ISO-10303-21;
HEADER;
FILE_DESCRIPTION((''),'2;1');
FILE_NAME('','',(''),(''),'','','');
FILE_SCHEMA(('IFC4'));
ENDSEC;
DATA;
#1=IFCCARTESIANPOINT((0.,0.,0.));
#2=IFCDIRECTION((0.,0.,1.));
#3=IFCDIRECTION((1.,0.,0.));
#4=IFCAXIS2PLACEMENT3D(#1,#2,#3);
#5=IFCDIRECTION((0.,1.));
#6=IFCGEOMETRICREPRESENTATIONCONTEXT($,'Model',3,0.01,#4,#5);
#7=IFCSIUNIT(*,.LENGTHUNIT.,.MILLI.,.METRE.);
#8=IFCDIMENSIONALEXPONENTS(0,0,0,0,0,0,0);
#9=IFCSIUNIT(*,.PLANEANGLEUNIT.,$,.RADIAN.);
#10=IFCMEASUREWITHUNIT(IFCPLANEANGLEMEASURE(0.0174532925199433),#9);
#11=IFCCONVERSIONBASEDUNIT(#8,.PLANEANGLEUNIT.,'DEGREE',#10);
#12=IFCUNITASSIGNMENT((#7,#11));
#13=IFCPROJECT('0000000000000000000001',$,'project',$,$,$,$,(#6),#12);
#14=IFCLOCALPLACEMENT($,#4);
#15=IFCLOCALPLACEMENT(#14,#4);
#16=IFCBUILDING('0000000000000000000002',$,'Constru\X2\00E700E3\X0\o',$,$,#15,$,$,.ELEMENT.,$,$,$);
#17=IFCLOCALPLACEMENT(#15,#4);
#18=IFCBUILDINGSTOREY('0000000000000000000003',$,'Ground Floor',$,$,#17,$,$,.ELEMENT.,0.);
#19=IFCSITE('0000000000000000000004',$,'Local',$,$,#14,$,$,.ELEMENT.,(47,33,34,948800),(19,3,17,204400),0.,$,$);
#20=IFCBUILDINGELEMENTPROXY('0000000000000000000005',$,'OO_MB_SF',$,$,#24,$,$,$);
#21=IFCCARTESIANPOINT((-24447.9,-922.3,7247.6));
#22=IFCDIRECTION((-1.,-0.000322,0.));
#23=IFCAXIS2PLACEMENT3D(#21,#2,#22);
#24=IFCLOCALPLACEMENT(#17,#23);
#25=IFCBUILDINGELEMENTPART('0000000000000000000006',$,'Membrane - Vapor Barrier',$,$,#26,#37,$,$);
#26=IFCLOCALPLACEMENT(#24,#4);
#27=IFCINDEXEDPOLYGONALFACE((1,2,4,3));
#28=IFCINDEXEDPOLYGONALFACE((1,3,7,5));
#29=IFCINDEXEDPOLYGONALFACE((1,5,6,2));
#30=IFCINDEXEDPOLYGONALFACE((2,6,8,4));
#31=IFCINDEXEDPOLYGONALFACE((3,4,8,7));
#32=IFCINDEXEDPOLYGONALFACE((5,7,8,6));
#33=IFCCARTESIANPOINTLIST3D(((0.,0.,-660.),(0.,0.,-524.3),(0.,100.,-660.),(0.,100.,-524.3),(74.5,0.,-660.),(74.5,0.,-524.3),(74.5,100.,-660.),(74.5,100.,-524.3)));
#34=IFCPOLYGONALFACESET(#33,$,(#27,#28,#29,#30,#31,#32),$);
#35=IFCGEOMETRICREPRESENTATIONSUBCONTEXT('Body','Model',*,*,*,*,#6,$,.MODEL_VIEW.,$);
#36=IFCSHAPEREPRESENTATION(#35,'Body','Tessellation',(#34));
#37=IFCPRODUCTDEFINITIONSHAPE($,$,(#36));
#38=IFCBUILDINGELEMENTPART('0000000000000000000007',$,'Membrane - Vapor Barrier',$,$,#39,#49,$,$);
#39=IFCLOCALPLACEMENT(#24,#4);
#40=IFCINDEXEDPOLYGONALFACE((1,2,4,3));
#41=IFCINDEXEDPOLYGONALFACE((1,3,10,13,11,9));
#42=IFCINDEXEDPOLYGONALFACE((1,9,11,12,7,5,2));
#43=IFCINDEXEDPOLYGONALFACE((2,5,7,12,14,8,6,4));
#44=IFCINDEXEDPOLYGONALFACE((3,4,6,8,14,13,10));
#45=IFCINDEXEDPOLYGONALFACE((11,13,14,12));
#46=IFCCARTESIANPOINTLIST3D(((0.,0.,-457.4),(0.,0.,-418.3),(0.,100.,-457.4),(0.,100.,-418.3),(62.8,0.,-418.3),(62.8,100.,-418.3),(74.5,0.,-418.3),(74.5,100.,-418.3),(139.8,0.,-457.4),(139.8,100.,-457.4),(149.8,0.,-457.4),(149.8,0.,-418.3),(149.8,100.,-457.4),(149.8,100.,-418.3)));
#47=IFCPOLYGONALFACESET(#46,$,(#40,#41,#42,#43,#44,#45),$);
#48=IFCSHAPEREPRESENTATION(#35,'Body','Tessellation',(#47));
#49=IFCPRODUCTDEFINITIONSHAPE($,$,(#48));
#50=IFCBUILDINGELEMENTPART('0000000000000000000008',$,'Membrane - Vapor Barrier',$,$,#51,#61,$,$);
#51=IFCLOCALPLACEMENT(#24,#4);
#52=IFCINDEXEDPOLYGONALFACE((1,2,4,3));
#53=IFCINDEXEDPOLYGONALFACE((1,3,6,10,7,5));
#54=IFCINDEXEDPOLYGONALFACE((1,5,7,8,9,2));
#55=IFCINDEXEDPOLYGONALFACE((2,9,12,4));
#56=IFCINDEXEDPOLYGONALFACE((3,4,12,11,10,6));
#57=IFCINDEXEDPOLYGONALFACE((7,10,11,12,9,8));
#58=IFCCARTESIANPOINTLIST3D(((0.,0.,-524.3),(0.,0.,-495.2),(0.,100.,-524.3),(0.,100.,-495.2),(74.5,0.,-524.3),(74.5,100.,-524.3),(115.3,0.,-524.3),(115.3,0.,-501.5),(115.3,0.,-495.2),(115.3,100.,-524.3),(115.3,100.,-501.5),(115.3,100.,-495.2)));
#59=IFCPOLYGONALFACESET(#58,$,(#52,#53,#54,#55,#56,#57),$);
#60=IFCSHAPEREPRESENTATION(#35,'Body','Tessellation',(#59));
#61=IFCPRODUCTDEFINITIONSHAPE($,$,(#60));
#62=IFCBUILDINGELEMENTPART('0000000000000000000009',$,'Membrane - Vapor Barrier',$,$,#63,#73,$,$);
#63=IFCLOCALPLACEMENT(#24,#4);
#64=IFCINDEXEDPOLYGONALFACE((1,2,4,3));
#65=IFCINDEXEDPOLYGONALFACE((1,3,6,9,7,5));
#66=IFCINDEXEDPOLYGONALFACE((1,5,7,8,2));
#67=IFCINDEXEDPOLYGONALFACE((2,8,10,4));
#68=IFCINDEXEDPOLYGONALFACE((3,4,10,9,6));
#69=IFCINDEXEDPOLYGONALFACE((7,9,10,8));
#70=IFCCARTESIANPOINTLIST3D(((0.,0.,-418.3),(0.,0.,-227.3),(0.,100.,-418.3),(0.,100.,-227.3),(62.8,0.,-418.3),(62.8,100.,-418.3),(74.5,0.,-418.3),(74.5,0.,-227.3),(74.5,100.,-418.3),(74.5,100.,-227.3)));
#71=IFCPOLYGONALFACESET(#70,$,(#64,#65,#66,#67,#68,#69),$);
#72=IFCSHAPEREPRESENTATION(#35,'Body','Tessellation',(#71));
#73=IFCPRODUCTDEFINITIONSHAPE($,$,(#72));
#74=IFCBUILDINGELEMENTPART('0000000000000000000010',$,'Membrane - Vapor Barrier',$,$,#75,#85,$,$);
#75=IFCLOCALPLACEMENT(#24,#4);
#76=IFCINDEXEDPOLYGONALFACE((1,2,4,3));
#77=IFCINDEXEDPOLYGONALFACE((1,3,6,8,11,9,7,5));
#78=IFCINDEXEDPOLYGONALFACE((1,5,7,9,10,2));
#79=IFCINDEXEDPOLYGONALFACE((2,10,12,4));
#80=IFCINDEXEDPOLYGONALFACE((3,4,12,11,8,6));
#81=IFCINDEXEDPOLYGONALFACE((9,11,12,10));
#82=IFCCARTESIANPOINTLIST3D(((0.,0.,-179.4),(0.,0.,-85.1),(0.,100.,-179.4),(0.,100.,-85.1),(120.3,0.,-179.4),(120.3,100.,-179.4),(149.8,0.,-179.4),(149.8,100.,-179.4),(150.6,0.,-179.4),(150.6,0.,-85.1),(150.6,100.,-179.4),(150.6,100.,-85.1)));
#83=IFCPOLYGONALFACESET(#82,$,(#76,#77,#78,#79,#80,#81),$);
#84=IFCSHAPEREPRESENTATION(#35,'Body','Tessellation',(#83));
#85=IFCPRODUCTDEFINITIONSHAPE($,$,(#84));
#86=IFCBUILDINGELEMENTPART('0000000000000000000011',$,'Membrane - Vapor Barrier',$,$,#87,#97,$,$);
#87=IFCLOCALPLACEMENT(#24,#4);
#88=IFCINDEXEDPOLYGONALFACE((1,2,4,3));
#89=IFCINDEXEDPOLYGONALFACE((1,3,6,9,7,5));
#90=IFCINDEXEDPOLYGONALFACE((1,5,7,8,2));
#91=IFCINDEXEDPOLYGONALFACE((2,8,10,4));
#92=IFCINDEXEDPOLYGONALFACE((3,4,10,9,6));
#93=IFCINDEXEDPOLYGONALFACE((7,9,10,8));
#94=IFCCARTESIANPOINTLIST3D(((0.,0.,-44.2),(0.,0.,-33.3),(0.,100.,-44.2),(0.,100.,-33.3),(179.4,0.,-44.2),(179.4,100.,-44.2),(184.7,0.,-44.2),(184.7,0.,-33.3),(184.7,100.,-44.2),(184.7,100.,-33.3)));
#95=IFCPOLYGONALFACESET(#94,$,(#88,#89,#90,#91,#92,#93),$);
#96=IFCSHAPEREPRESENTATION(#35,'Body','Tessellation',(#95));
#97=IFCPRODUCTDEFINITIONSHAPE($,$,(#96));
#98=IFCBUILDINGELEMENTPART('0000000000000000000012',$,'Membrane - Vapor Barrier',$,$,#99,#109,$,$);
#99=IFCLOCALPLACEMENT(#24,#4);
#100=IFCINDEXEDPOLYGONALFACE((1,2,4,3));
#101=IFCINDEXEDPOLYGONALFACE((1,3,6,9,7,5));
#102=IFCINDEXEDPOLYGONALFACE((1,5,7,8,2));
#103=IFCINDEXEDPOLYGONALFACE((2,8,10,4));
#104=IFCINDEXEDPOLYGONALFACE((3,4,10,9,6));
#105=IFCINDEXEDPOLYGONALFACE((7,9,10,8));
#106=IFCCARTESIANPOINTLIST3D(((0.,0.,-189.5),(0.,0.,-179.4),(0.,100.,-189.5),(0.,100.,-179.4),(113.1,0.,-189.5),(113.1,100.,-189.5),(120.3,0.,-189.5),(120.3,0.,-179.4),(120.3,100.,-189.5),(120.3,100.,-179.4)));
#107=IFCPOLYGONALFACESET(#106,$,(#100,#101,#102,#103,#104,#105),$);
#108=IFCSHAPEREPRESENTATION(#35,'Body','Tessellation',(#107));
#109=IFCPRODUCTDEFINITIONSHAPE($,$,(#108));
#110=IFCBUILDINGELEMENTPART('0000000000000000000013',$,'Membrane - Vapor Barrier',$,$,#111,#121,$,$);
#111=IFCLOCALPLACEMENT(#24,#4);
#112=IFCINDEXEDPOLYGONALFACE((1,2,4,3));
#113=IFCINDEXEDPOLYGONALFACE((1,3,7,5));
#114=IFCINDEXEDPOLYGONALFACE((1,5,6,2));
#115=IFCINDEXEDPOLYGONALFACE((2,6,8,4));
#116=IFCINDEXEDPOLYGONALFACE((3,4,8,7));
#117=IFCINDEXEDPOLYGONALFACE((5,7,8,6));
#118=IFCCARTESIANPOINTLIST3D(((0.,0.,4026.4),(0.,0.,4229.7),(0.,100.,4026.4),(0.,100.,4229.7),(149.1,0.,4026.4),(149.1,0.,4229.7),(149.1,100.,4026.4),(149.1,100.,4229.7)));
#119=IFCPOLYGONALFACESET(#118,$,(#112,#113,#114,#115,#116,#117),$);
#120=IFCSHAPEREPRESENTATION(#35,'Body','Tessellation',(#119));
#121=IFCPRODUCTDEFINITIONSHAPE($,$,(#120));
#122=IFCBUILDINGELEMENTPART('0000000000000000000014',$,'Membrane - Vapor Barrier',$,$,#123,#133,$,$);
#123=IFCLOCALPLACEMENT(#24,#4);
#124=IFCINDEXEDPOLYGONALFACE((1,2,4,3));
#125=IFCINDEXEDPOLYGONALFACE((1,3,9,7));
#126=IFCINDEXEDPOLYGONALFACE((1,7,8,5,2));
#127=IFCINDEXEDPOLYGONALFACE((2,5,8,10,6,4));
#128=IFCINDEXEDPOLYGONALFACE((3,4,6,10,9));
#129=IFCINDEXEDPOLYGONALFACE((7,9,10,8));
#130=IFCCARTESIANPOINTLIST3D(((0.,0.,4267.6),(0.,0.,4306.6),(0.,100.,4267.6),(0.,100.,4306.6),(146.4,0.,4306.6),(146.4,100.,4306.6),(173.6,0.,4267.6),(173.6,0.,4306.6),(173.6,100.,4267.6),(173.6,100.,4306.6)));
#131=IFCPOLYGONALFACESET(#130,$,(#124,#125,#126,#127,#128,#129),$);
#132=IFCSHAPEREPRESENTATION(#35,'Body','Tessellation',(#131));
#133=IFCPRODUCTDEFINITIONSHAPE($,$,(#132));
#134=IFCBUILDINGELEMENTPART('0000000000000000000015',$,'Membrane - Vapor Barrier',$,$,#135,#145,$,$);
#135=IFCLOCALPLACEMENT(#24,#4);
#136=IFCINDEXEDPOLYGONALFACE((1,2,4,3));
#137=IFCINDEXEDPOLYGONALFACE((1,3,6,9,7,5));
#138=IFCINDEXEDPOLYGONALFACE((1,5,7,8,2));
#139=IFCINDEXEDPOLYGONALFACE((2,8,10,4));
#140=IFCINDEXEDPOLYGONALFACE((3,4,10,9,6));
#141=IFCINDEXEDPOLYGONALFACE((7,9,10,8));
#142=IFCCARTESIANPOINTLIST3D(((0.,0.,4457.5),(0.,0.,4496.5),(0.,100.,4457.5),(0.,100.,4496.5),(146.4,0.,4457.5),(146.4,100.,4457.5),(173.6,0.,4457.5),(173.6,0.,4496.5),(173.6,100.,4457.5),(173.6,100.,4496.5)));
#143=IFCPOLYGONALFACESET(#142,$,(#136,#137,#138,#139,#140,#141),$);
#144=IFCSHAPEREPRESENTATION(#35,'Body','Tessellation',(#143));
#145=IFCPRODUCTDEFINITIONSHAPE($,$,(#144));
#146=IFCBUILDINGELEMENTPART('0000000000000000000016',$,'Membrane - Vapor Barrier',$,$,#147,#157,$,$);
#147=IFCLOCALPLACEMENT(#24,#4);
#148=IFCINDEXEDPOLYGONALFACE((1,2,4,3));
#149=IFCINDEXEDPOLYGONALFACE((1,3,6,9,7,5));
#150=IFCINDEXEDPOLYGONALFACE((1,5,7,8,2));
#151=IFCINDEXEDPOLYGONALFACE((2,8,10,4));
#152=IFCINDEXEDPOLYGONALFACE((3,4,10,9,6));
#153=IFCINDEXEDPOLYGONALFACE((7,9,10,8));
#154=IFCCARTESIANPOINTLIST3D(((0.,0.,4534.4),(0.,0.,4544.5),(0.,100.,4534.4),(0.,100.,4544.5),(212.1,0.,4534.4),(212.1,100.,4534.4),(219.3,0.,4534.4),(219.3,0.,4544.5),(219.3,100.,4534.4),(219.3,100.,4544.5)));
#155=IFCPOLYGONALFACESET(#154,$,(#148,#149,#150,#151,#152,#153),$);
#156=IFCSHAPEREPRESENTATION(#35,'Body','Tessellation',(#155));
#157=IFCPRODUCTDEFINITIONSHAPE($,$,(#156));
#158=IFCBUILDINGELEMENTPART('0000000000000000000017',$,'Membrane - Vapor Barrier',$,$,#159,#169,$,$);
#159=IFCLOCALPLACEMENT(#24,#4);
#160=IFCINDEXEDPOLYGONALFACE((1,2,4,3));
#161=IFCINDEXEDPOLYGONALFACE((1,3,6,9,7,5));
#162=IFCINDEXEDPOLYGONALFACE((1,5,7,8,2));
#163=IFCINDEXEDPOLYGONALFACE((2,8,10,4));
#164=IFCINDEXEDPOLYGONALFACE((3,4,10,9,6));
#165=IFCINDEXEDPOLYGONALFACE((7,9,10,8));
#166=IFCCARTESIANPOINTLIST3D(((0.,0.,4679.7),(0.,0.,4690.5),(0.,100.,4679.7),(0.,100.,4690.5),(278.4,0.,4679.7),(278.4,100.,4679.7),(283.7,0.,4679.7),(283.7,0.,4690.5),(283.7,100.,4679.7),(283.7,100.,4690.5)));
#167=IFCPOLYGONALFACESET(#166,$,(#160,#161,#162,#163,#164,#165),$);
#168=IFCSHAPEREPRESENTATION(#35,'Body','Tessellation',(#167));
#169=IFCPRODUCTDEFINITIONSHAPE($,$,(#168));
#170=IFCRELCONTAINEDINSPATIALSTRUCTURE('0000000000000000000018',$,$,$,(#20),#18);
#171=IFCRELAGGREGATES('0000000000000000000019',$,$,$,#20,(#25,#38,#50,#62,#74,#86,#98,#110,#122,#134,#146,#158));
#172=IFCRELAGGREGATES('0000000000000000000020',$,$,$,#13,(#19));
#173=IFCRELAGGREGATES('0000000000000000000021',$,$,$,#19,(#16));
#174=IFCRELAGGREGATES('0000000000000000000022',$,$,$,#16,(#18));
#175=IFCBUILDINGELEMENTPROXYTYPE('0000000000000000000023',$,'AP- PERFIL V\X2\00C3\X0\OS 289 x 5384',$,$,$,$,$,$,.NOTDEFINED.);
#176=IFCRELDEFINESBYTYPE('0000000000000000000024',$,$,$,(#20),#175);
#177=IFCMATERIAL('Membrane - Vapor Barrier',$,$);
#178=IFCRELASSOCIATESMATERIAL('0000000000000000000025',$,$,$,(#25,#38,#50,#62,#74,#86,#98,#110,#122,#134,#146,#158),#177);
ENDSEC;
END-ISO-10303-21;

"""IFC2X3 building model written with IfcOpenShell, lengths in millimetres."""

from ifc_helpers import new_model, entity, si_unit, converted_unit, direction, frame, origin_with_axes, place, context, subcontext, project, spatial, polyline, outline, extrude, material, type_object, element, aggregate, save


model = new_model("IFC2X3")

# Units and contexts
model_context = context("Model", 3, precision=0.01, world=origin_with_axes(), true_north=direction((0.0, 1.0)))
body_context = subcontext(model_context, "Body", "Model", "MODEL_VIEW")
ifc_project = project(units=[si_unit("LENGTHUNIT", "METRE", prefix="MILLI"), converted_unit("PLANEANGLEUNIT", "DEGREE", entity("IfcPlaneAngleMeasure", 0.0174532925199433), si_unit("PLANEANGLEUNIT", "RADIAN"), dimensions=[0, 0, 0, 0, 0, 0, 0])], contexts=[model_context])

# Site, building, storey
site_placement = place(None, origin_with_axes())
site = spatial("IfcSite", under=ifc_project, at=site_placement, Name="Local", CompositionType="ELEMENT", RefLatitude=(47, 33, 34, 948800), RefLongitude=(19, 3, 17, 204400), RefElevation=0.0)
building_placement = place(site_placement, origin_with_axes())
building = spatial("IfcBuilding", under=site, at=building_placement, Name="Construção", CompositionType="ELEMENT")
storey_placement = place(building_placement, origin_with_axes())
storey = spatial("IfcBuildingStorey", under=building, at=storey_placement, Name="Ground Floor", CompositionType="ELEMENT", Elevation=0.0)

# Building element proxy, building element parts
building_element_proxy_type = type_object("IfcBuildingElementProxyType", Name="AP- PERFIL VÃOS 289 x 5384", PredefinedType="NOTDEFINED")
proxy_1_placement = place(storey_placement, frame((-24447.9, -922.3, 7247.6), z_axis=(0.0, 0.0, 1.0), x_axis=(-1.0, -0.000322, 0.0)))
proxy_1 = element("IfcBuildingElementProxy", 1, at=proxy_1_placement, inside=storey, type_object=building_element_proxy_type, Name="OO_MB_SF")
ifc_material = material(Name="Membrane - Vapor Barrier")
building_element_part_1_placement = place(proxy_1_placement, origin_with_axes())
building_element_part_1 = element("IfcBuildingElementPart", 2, at=building_element_part_1_placement, material=ifc_material, Name="Membrane - Vapor Barrier", context=body_context, shape_type="SweptSolid", body=[
    extrude(outline(polyline([(0.0, -660.0), (74.5, -660.0), (74.5, -524.3), (0.0, -524.3), (0.0, -660.0)])), frame((0.0, 100.0, 0.0), z_axis=(0.0, -1.0, 0.0), x_axis=(1.0, 0.0, 0.0)), (0.0, 0.0, 1.0), 100.0),
])
building_element_part_2_placement = place(proxy_1_placement, origin_with_axes())
building_element_part_2 = element("IfcBuildingElementPart", 3, at=building_element_part_2_placement, material=ifc_material, Name="Membrane - Vapor Barrier", context=body_context, shape_type="SweptSolid", body=[
    extrude(outline(polyline([(62.8, -418.3), (0.0, -418.3), (0.0, -457.4), (139.8, -457.4), (149.8, -457.4), (149.8, -418.3), (74.5, -418.3), (62.8, -418.3)])), frame((0.0, 100.0, 0.0), z_axis=(0.0, -1.0, 0.0), x_axis=(1.0, 0.0, 0.0)), (0.0, 0.0, 1.0), 100.0),
])
building_element_part_3_placement = place(proxy_1_placement, origin_with_axes())
building_element_part_3 = element("IfcBuildingElementPart", 4, at=building_element_part_3_placement, material=ifc_material, Name="Membrane - Vapor Barrier", context=body_context, shape_type="SweptSolid", body=[
    extrude(outline(polyline([(0.0, -524.3), (74.5, -524.3), (115.3, -524.3), (115.3, -501.5), (115.3, -495.2), (0.0, -495.2), (0.0, -524.3)])), frame((0.0, 100.0, 0.0), z_axis=(0.0, -1.0, 0.0), x_axis=(1.0, 0.0, 0.0)), (0.0, 0.0, 1.0), 100.0),
])
building_element_part_4_placement = place(proxy_1_placement, origin_with_axes())
building_element_part_4 = element("IfcBuildingElementPart", 5, at=building_element_part_4_placement, material=ifc_material, Name="Membrane - Vapor Barrier", context=body_context, shape_type="SweptSolid", body=[
    extrude(outline(polyline([(0.0, -227.3), (0.0, -418.3), (62.8, -418.3), (74.5, -418.3), (74.5, -227.3), (0.0, -227.3)])), frame((0.0, 100.0, 0.0), z_axis=(0.0, -1.0, 0.0), x_axis=(1.0, 0.0, 0.0)), (0.0, 0.0, 1.0), 100.0),
])
building_element_part_5_placement = place(proxy_1_placement, origin_with_axes())
building_element_part_5 = element("IfcBuildingElementPart", 6, at=building_element_part_5_placement, material=ifc_material, Name="Membrane - Vapor Barrier", context=body_context, shape_type="SweptSolid", body=[
    extrude(outline(polyline([(0.0, -85.1), (0.0, -179.4), (120.3, -179.4), (149.8, -179.4), (150.6, -179.4), (150.6, -85.1), (0.0, -85.1)])), frame((0.0, 100.0, 0.0), z_axis=(0.0, -1.0, 0.0), x_axis=(1.0, 0.0, 0.0)), (0.0, 0.0, 1.0), 100.0),
])
building_element_part_6_placement = place(proxy_1_placement, origin_with_axes())
building_element_part_6 = element("IfcBuildingElementPart", 7, at=building_element_part_6_placement, material=ifc_material, Name="Membrane - Vapor Barrier", context=body_context, shape_type="SweptSolid", body=[
    extrude(outline(polyline([(184.7, -33.3), (0.0, -33.3), (0.0, -44.2), (179.4, -44.2), (184.7, -44.2), (184.7, -33.3)])), frame((0.0, 100.0, 0.0), z_axis=(0.0, -1.0, 0.0), x_axis=(1.0, 0.0, 0.0)), (0.0, 0.0, 1.0), 100.0),
])
building_element_part_7_placement = place(proxy_1_placement, origin_with_axes())
building_element_part_7 = element("IfcBuildingElementPart", 8, at=building_element_part_7_placement, material=ifc_material, Name="Membrane - Vapor Barrier", context=body_context, shape_type="SweptSolid", body=[
    extrude(outline(polyline([(120.3, -179.4), (0.0, -179.4), (0.0, -189.5), (113.1, -189.5), (120.3, -189.5), (120.3, -179.4)])), frame((0.0, 100.0, 0.0), z_axis=(0.0, -1.0, 0.0), x_axis=(1.0, 0.0, 0.0)), (0.0, 0.0, 1.0), 100.0),
])
building_element_part_8_placement = place(proxy_1_placement, origin_with_axes())
building_element_part_8 = element("IfcBuildingElementPart", 9, at=building_element_part_8_placement, material=ifc_material, Name="Membrane - Vapor Barrier", context=body_context, shape_type="SweptSolid", body=[
    extrude(outline(polyline([(149.1, 4229.7), (0.0, 4229.7), (0.0, 4026.4), (149.1, 4026.4), (149.1, 4229.7)])), frame((0.0, 100.0, 0.0), z_axis=(0.0, -1.0, 0.0), x_axis=(1.0, 0.0, 0.0)), (0.0, 0.0, 1.0), 100.0),
])
building_element_part_9_placement = place(proxy_1_placement, origin_with_axes())
building_element_part_9 = element("IfcBuildingElementPart", 10, at=building_element_part_9_placement, material=ifc_material, Name="Membrane - Vapor Barrier", context=body_context, shape_type="SweptSolid", body=[
    extrude(outline(polyline([(0.0, 4306.6), (0.0, 4267.6), (173.6, 4267.6), (173.6, 4306.6), (146.4, 4306.6), (0.0, 4306.6)])), frame((0.0, 100.0, 0.0), z_axis=(0.0, -1.0, 0.0), x_axis=(1.0, 0.0, 0.0)), (0.0, 0.0, 1.0), 100.0),
])
building_element_part_10_placement = place(proxy_1_placement, origin_with_axes())
building_element_part_10 = element("IfcBuildingElementPart", 11, at=building_element_part_10_placement, material=ifc_material, Name="Membrane - Vapor Barrier", context=body_context, shape_type="SweptSolid", body=[
    extrude(outline(polyline([(173.6, 4496.5), (0.0, 4496.5), (0.0, 4457.5), (146.4, 4457.5), (173.6, 4457.5), (173.6, 4496.5)])), frame((0.0, 100.0, 0.0), z_axis=(0.0, -1.0, 0.0), x_axis=(1.0, 0.0, 0.0)), (0.0, 0.0, 1.0), 100.0),
])
building_element_part_11_placement = place(proxy_1_placement, origin_with_axes())
building_element_part_11 = element("IfcBuildingElementPart", 12, at=building_element_part_11_placement, material=ifc_material, Name="Membrane - Vapor Barrier", context=body_context, shape_type="SweptSolid", body=[
    extrude(outline(polyline([(0.0, 4534.4), (212.1, 4534.4), (219.3, 4534.4), (219.3, 4544.5), (0.0, 4544.5), (0.0, 4534.4)])), frame((0.0, 100.0, 0.0), z_axis=(0.0, -1.0, 0.0), x_axis=(1.0, 0.0, 0.0)), (0.0, 0.0, 1.0), 100.0),
])
building_element_part_12_placement = place(proxy_1_placement, origin_with_axes())
building_element_part_12 = element("IfcBuildingElementPart", 13, at=building_element_part_12_placement, material=ifc_material, Name="Membrane - Vapor Barrier", context=body_context, shape_type="SweptSolid", body=[
    extrude(outline(polyline([(0.0, 4679.7), (278.4, 4679.7), (283.7, 4679.7), (283.7, 4690.5), (0.0, 4690.5), (0.0, 4679.7)])), frame((0.0, 100.0, 0.0), z_axis=(0.0, -1.0, 0.0), x_axis=(1.0, 0.0, 0.0)), (0.0, 0.0, 1.0), 100.0),
])
aggregate(proxy_1, [building_element_part_1, building_element_part_2, building_element_part_3, building_element_part_4, building_element_part_5, building_element_part_6, building_element_part_7, building_element_part_8, building_element_part_9, building_element_part_10, building_element_part_11, building_element_part_12])

save(model, "model.ifc")
